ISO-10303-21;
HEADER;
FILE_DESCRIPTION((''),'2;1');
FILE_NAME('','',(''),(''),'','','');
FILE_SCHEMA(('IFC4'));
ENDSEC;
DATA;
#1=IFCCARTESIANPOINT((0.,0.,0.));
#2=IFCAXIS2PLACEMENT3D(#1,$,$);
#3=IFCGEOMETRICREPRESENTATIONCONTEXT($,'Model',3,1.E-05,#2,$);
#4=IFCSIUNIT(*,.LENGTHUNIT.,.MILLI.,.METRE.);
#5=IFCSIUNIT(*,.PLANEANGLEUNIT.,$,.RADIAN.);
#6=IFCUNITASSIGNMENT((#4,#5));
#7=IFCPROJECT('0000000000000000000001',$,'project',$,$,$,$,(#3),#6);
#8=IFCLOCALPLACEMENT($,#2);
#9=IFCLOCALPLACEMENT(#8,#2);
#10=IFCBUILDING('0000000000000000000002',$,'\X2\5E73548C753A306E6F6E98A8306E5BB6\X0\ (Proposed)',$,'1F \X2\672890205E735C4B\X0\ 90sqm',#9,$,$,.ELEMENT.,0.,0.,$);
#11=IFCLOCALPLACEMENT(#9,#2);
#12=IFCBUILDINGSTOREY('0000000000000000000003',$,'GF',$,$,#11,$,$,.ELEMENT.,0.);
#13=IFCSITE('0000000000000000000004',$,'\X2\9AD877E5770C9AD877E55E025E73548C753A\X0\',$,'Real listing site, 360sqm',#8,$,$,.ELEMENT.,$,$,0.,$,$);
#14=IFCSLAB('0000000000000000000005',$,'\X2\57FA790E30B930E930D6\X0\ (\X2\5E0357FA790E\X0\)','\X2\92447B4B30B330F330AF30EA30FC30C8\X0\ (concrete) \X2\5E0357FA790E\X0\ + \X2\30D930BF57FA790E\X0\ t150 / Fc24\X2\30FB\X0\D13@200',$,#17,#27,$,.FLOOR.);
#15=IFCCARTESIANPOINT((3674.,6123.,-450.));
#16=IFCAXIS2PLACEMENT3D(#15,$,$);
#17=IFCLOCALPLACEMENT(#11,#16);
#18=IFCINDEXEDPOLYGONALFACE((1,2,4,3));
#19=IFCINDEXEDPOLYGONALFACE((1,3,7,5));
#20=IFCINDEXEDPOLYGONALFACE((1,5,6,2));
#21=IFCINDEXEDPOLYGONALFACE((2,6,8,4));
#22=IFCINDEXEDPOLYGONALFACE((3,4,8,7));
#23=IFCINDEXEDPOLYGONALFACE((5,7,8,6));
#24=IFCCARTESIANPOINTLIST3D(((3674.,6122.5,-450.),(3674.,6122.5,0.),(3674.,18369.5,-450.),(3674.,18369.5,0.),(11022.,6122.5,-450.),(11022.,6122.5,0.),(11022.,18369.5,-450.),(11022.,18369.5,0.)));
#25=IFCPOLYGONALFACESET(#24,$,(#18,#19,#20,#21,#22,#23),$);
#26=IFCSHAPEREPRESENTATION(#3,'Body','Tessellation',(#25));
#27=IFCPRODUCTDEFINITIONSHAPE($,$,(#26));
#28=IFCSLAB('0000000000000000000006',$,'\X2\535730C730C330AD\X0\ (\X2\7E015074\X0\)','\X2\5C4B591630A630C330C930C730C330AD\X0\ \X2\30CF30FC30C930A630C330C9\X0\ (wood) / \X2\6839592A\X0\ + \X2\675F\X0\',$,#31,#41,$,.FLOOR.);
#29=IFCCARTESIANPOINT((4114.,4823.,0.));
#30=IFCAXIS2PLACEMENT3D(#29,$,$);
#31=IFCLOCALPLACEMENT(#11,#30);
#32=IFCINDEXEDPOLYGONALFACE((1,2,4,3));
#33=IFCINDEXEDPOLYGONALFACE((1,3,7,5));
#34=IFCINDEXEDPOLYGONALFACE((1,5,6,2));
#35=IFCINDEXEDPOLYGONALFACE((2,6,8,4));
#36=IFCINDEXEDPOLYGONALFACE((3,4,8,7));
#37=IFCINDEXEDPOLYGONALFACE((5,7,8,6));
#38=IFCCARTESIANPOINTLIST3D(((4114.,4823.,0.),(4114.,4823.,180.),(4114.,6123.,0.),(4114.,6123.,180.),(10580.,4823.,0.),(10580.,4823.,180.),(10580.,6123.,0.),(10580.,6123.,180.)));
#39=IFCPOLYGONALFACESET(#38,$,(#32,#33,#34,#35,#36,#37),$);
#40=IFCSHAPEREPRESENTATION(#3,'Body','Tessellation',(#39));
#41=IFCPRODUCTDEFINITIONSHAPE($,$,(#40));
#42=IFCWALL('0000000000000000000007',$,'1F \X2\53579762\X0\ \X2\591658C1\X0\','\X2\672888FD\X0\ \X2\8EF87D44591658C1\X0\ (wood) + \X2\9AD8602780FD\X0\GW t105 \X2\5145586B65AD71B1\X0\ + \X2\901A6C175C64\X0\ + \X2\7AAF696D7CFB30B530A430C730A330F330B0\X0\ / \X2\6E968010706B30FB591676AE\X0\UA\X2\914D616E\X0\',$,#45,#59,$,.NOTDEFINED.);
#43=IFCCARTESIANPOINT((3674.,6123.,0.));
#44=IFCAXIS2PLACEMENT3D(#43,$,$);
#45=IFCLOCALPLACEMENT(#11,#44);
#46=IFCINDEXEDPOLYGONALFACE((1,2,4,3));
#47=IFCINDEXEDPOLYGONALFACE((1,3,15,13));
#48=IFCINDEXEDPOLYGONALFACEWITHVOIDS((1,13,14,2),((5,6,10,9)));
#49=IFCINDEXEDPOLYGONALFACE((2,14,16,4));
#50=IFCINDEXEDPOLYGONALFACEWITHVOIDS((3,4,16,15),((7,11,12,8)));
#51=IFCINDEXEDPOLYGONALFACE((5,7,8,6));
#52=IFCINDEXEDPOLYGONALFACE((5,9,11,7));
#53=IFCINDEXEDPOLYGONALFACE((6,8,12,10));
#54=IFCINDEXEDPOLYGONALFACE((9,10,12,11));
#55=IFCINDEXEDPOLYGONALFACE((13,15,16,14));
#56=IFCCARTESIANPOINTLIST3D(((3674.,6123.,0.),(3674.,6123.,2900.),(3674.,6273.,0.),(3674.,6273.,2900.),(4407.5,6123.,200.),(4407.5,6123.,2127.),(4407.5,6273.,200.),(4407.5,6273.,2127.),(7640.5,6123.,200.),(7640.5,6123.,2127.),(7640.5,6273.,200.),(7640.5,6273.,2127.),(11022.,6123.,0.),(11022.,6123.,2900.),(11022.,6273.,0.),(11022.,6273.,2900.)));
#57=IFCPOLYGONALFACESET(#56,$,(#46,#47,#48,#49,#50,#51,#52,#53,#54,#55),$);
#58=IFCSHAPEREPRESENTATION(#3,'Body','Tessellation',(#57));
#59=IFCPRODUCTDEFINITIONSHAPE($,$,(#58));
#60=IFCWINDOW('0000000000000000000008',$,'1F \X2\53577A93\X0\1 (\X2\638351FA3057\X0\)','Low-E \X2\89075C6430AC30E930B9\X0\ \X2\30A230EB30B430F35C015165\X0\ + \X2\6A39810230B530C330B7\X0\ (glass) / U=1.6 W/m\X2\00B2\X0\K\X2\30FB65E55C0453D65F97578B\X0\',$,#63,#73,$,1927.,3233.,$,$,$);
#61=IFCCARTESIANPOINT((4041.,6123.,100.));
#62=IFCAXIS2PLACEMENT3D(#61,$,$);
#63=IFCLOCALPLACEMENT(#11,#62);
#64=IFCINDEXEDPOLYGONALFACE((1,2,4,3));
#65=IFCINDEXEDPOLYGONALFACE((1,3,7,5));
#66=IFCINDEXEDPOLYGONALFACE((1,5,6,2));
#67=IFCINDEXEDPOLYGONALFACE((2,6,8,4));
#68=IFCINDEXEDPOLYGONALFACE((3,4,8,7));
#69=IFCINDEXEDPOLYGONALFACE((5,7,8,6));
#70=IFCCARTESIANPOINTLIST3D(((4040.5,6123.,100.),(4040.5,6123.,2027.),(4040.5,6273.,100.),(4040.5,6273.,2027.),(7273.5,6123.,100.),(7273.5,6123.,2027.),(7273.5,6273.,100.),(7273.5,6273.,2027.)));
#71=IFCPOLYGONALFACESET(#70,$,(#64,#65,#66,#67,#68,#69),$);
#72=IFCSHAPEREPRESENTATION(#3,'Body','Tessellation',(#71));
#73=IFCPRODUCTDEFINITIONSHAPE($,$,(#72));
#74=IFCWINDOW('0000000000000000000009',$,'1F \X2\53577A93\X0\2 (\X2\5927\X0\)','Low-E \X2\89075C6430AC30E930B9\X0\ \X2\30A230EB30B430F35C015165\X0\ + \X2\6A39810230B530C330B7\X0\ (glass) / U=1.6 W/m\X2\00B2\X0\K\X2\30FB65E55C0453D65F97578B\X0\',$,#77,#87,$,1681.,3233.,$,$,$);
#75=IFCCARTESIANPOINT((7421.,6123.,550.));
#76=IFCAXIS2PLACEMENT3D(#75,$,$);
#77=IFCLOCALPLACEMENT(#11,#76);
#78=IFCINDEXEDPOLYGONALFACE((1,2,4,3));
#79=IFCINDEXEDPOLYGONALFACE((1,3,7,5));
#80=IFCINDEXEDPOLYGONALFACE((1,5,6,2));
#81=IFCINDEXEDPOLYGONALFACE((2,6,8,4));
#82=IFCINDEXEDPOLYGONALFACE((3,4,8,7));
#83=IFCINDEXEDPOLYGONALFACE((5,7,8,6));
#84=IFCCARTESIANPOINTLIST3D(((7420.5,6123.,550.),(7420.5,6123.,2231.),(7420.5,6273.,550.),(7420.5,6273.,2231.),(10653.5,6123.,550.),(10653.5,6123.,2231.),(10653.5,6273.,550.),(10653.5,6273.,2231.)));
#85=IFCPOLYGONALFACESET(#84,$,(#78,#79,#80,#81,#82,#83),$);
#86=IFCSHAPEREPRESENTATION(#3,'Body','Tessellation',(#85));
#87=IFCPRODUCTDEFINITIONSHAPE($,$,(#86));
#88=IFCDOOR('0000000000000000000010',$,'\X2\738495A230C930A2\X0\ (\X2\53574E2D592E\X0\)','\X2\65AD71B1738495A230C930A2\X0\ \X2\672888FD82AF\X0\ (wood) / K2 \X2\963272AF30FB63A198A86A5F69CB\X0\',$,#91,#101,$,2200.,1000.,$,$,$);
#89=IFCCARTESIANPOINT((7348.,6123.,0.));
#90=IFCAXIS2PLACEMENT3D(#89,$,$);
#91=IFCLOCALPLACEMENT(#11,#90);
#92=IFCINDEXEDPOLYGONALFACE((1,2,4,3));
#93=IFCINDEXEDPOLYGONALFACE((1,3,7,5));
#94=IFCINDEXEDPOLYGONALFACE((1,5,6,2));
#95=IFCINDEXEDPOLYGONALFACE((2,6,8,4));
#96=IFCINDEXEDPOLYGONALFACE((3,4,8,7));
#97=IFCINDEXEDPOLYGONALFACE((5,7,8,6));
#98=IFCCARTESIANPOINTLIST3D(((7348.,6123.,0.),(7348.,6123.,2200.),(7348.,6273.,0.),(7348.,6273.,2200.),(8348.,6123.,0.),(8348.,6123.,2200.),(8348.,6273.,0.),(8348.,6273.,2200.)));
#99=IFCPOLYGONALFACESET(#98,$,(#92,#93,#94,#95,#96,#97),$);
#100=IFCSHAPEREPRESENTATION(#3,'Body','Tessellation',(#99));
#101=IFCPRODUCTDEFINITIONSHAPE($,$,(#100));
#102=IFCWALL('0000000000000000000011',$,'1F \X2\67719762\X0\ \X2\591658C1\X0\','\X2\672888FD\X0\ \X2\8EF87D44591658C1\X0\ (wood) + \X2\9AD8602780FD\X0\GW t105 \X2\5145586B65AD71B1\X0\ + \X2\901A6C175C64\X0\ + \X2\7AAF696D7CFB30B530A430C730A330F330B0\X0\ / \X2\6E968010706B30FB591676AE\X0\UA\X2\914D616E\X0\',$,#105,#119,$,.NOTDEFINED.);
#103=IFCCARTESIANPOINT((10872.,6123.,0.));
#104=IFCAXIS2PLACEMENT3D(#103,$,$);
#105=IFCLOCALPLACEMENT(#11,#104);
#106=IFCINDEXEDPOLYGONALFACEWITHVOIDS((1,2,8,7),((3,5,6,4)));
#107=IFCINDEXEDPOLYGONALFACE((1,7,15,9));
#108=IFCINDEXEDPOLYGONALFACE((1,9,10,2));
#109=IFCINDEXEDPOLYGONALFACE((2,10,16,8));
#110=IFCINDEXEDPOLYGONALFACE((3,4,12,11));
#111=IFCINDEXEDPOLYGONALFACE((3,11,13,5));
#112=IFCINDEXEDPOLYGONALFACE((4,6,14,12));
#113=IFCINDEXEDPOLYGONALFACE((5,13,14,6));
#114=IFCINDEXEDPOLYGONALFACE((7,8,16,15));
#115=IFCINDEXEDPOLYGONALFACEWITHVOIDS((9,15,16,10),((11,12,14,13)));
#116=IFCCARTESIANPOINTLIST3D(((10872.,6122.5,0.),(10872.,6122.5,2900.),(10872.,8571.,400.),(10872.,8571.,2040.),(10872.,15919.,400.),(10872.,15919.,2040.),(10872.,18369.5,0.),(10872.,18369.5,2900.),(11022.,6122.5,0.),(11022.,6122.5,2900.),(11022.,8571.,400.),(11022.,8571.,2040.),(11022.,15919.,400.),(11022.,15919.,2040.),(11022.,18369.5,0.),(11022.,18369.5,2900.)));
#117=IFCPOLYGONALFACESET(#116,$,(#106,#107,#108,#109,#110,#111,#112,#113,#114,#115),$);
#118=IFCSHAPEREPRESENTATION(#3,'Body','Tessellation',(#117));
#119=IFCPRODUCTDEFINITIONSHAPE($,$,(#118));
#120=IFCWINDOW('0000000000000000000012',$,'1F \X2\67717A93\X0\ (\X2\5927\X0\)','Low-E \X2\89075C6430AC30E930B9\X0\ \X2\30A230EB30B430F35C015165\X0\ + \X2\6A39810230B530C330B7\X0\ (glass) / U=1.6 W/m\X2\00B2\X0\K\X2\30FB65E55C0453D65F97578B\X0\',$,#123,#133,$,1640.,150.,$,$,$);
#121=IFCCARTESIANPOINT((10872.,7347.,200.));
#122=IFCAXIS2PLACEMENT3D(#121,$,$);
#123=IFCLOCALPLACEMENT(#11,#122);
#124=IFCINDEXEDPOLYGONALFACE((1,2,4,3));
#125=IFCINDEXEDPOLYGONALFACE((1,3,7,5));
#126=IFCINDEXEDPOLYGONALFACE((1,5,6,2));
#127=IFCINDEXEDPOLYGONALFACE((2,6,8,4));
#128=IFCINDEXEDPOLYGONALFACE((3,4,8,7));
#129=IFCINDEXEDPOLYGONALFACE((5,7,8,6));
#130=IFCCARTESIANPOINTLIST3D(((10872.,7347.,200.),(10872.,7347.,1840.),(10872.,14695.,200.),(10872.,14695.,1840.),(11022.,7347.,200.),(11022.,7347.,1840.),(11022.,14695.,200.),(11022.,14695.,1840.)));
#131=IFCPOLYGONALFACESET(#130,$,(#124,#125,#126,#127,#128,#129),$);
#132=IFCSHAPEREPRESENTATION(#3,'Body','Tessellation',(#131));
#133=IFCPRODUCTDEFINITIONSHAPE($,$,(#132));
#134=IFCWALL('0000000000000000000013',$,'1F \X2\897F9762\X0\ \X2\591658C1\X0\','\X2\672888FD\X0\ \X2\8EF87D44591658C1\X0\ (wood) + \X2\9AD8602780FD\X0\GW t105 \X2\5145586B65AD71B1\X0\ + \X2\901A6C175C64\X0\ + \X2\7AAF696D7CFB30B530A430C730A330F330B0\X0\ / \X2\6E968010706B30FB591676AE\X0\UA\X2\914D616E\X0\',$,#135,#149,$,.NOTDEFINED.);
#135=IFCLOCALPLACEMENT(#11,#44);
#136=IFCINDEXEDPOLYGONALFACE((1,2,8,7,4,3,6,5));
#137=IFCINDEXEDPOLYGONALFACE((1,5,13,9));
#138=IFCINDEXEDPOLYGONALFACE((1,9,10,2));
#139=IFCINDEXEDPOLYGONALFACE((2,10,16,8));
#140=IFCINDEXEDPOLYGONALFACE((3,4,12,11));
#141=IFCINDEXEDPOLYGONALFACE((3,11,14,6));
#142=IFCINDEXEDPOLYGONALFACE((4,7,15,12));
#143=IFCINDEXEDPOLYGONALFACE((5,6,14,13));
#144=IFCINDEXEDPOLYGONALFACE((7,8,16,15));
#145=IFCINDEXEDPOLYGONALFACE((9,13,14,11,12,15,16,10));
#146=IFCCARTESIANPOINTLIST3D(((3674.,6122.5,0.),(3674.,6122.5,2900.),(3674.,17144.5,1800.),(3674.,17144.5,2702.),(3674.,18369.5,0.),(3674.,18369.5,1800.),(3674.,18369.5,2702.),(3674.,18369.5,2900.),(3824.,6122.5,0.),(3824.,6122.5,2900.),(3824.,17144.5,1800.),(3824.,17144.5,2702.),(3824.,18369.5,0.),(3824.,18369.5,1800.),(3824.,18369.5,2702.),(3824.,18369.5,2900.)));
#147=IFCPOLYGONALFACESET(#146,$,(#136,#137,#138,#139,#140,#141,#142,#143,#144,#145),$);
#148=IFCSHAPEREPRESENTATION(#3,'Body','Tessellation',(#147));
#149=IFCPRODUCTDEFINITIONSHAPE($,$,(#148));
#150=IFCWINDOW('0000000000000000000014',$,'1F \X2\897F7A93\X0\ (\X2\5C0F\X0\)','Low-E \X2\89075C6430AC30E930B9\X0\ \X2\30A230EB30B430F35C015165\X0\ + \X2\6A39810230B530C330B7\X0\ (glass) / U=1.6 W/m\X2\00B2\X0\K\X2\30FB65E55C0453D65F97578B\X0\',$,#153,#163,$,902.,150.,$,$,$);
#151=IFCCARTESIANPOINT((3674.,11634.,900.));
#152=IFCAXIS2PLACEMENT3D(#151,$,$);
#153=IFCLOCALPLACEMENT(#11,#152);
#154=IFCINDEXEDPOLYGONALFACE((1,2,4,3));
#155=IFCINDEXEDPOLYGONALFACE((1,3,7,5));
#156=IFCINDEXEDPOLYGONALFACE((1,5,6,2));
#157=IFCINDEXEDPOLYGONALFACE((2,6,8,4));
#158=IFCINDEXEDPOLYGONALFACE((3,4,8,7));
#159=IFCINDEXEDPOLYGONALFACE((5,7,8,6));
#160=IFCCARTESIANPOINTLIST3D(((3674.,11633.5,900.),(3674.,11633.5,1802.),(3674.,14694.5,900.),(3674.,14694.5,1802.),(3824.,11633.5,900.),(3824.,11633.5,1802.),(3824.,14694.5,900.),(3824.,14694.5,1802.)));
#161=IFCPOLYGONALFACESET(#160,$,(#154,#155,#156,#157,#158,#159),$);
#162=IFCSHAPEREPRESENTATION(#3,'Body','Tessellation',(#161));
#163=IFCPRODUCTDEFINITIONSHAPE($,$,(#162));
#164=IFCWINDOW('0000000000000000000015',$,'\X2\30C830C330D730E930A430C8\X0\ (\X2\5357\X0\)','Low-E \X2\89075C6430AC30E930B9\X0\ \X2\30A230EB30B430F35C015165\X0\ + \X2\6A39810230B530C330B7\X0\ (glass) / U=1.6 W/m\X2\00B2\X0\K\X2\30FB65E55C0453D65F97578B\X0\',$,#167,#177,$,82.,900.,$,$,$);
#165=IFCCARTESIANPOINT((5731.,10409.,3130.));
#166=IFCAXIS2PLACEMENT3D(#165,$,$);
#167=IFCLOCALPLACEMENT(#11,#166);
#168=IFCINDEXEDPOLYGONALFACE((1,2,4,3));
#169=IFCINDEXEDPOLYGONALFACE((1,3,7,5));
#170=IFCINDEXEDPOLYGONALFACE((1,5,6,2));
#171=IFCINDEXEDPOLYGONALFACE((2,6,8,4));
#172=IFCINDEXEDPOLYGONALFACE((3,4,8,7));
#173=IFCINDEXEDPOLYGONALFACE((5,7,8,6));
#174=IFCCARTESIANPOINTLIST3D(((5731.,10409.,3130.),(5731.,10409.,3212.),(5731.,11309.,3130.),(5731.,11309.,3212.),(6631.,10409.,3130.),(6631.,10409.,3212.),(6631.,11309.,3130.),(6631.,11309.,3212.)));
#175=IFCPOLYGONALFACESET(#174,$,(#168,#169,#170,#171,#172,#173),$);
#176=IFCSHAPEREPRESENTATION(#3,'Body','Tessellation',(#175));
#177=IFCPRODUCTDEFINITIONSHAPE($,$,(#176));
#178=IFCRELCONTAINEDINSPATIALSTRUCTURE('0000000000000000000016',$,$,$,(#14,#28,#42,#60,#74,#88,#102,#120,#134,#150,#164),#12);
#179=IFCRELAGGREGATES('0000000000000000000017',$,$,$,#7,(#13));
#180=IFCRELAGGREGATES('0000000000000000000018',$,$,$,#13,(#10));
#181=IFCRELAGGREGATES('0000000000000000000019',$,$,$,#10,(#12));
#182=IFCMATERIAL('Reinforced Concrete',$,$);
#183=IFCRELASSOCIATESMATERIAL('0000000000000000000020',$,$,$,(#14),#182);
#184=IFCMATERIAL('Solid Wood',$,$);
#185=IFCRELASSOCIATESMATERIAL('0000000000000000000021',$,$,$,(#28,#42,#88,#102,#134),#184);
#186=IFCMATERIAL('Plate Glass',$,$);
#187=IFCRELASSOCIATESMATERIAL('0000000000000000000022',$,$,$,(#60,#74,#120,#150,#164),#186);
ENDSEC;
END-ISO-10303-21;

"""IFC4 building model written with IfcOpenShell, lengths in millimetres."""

from ifc_helpers import new_model, si_unit, frame, frame_2d, origin, place, context, project, spatial, rectangle, extrude, material, element, fill, save


model = new_model("IFC4")

# Units and contexts
model_context = context("Model", 3, precision=1e-05, world=origin())
ifc_project = project(units=[si_unit("LENGTHUNIT", "METRE", prefix="MILLI"), si_unit("PLANEANGLEUNIT", "RADIAN")], contexts=[model_context])

# Site, building, storey
site_placement = place(None, origin())
site = spatial("IfcSite", under=ifc_project, at=site_placement, Name="高知県高知市平和町", ObjectType="Real listing site, 360sqm", CompositionType="ELEMENT", RefElevation=0.0)
building_placement = place(site_placement, origin())
building = spatial("IfcBuilding", under=site, at=building_placement, Name="平和町の潮風の家 (Proposed)", ObjectType="1F 木造平屋 90sqm", CompositionType="ELEMENT", ElevationOfRefHeight=0.0, ElevationOfTerrain=0.0)
storey_placement = place(building_placement, origin())
storey = spatial("IfcBuildingStorey", under=building, at=storey_placement, Name="GF", CompositionType="ELEMENT", Elevation=0.0)

# Slabs
ifc_material_1 = material(Name="Reinforced Concrete")
slab_1_placement = place(storey_placement, frame((3674.0, 6123.0, -450.0)))
element("IfcSlab", 1, at=slab_1_placement, inside=storey, material=ifc_material_1, Name="基礎スラブ (布基礎)", Description="鉄筋コンクリート (concrete) 布基礎 + ベタ基礎 t150 / Fc24・D13@200", PredefinedType="FLOOR", context=model_context, shape_type="SweptSolid", body=[
    extrude(rectangle(XDim=7348.0, YDim=12247.0, at=frame_2d((3674.0, 6123.0))), frame((3674.0, 6123.0, -450.0)), (0.0, 0.0, 1.0), 450.0),
])
ifc_material_2 = material(Name="Solid Wood")
slab_2_placement = place(storey_placement, frame((4114.0, 4823.0, 0.0)))
element("IfcSlab", 2, at=slab_2_placement, inside=storey, material=ifc_material_2, Name="南デッキ (縁側)", Description="屋外ウッドデッキ ハードウッド (wood) / 根太 + 束", PredefinedType="FLOOR", context=model_context, shape_type="SweptSolid", body=[
    extrude(rectangle(XDim=6466.0, YDim=1300.0, at=frame_2d((3233.0, 650.0))), frame((4114.0, 4823.0, 0.0)), (0.0, 0.0, 1.0), 180.0),
])

# Wall, openings, windows, door
wall_1_placement = place(storey_placement, frame((3674.0, 6123.0, 0.0)))
wall_1 = element("IfcWall", 3, at=wall_1_placement, inside=storey, material=ifc_material_2, Name="1F 南面 外壁", Description="木製 軸組外壁 (wood) + 高性能GW t105 充填断熱 + 通気層 + 窯業系サイディング / 準耐火・外皮UA配慮", PredefinedType="NOTDEFINED", context=model_context, shape_type="SweptSolid", body=[
    extrude(rectangle(XDim=7348.0, YDim=150.0, at=frame_2d((3674.0, 75.0))), frame((3674.0, 6123.0, 0.0)), (0.0, 0.0, 1.0), 2900.0),
])
opening_1_placement = place(storey_placement, frame((4041.0, 6123.0, 100.0)))
opening_1 = element("IfcOpeningElement", 4, at=opening_1_placement, cuts=wall_1, PredefinedType="NOTDEFINED", context=model_context, shape_type="SweptSolid", body=[
    extrude(rectangle(XDim=3233.0, YDim=150.0, at=frame_2d((1616.0, 75.0))), frame((4041.0, 6123.0, 100.0)), (0.0, 0.0, 1.0), 1927.0),
])
opening_2_placement = place(storey_placement, frame((7421.0, 6123.0, 550.0)))
opening_2 = element("IfcOpeningElement", 5, at=opening_2_placement, cuts=wall_1, PredefinedType="NOTDEFINED", context=model_context, shape_type="SweptSolid", body=[
    extrude(rectangle(XDim=3233.0, YDim=150.0, at=frame_2d((1616.0, 75.0))), frame((7421.0, 6123.0, 550.0)), (0.0, 0.0, 1.0), 1681.0),
])
opening_3_placement = place(storey_placement, frame((7348.0, 6123.0, 0.0)))
opening_3 = element("IfcOpeningElement", 6, at=opening_3_placement, cuts=wall_1, PredefinedType="NOTDEFINED", context=model_context, shape_type="SweptSolid", body=[
    extrude(rectangle(XDim=1000.0, YDim=150.0, at=frame_2d((500.0, 75.0))), frame((7348.0, 6123.0, 0.0)), (0.0, 0.0, 1.0), 2200.0),
])
ifc_material_3 = material(Name="Plate Glass")
window_1_placement = place(storey_placement, frame((4041.0, 6123.0, 100.0)))
window_1 = element("IfcWindow", 7, at=window_1_placement, inside=storey, material=ifc_material_3, Name="1F 南窓1 (掃出し)", Description="Low-E 複層ガラス アルゴン封入 + 樹脂サッシ (glass) / U=1.6 W/m²K・日射取得型", OverallHeight=1927.0, OverallWidth=3233.0, context=model_context, shape_type="SweptSolid", body=[
    extrude(rectangle(XDim=3233.0, YDim=150.0, at=frame_2d((1616.0, 75.0))), frame((4041.0, 6123.0, 100.0)), (0.0, 0.0, 1.0), 1927.0),
])
fill(opening_1, window_1)
window_2_placement = place(storey_placement, frame((7421.0, 6123.0, 550.0)))
window_2 = element("IfcWindow", 8, at=window_2_placement, inside=storey, material=ifc_material_3, Name="1F 南窓2 (大)", Description="Low-E 複層ガラス アルゴン封入 + 樹脂サッシ (glass) / U=1.6 W/m²K・日射取得型", OverallHeight=1681.0, OverallWidth=3233.0, context=model_context, shape_type="SweptSolid", body=[
    extrude(rectangle(XDim=3233.0, YDim=150.0, at=frame_2d((1616.0, 75.0))), frame((7421.0, 6123.0, 550.0)), (0.0, 0.0, 1.0), 1681.0),
])
fill(opening_2, window_2)
door_placement = place(storey_placement, frame((7348.0, 6123.0, 0.0)))
door = element("IfcDoor", 9, at=door_placement, inside=storey, material=ifc_material_2, Name="玄関ドア (南中央)", Description="断熱玄関ドア 木製芯 (wood) / K2 防犯・採風機構", OverallHeight=2200.0, OverallWidth=1000.0, context=model_context, shape_type="SweptSolid", body=[
    extrude(rectangle(XDim=1000.0, YDim=150.0, at=frame_2d((500.0, 75.0))), frame((7348.0, 6123.0, 0.0)), (0.0, 0.0, 1.0), 2200.0),
])
fill(opening_3, door)

# Walls, openings, windows
wall_2_placement = place(storey_placement, frame((10872.0, 6123.0, 0.0)))
wall_2 = element("IfcWall", 10, at=wall_2_placement, inside=storey, material=ifc_material_2, Name="1F 東面 外壁", Description="木製 軸組外壁 (wood) + 高性能GW t105 充填断熱 + 通気層 + 窯業系サイディング / 準耐火・外皮UA配慮", PredefinedType="NOTDEFINED", context=model_context, shape_type="SweptSolid", body=[
    extrude(rectangle(XDim=150.0, YDim=12247.0, at=frame_2d((75.0, 6123.0))), frame((10872.0, 6123.0, 0.0)), (0.0, 0.0, 1.0), 2900.0),
])
opening_4_placement = place(storey_placement, frame((10872.0, 7347.0, 200.0)))
opening_4 = element("IfcOpeningElement", 11, at=opening_4_placement, cuts=wall_2, PredefinedType="NOTDEFINED", context=model_context, shape_type="SweptSolid", body=[
    extrude(rectangle(XDim=150.0, YDim=7348.0, at=frame_2d((75.0, 3674.0))), frame((10872.0, 7347.0, 200.0)), (0.0, 0.0, 1.0), 1640.0),
])
window_3_placement = place(storey_placement, frame((10872.0, 7347.0, 200.0)))
window_3 = element("IfcWindow", 12, at=window_3_placement, inside=storey, material=ifc_material_3, Name="1F 東窓 (大)", Description="Low-E 複層ガラス アルゴン封入 + 樹脂サッシ (glass) / U=1.6 W/m²K・日射取得型", OverallHeight=1640.0, OverallWidth=150.0, context=model_context, shape_type="SweptSolid", body=[
    extrude(rectangle(XDim=150.0, YDim=7348.0, at=frame_2d((75.0, 3674.0))), frame((10872.0, 7347.0, 200.0)), (0.0, 0.0, 1.0), 1640.0),
])
fill(opening_4, window_3)
wall_3_placement = place(storey_placement, frame((3674.0, 6123.0, 0.0)))
wall_3 = element("IfcWall", 13, at=wall_3_placement, inside=storey, material=ifc_material_2, Name="1F 西面 外壁", Description="木製 軸組外壁 (wood) + 高性能GW t105 充填断熱 + 通気層 + 窯業系サイディング / 準耐火・外皮UA配慮", PredefinedType="NOTDEFINED", context=model_context, shape_type="SweptSolid", body=[
    extrude(rectangle(XDim=150.0, YDim=12247.0, at=frame_2d((75.0, 6123.0))), frame((3674.0, 6123.0, 0.0)), (0.0, 0.0, 1.0), 2900.0),
])
opening_5_placement = place(storey_placement, frame((3674.0, 11634.0, 900.0)))
opening_5 = element("IfcOpeningElement", 14, at=opening_5_placement, cuts=wall_3, PredefinedType="NOTDEFINED", context=model_context, shape_type="SweptSolid", body=[
    extrude(rectangle(XDim=150.0, YDim=3061.0, at=frame_2d((75.0, 1530.0))), frame((3674.0, 11634.0, 900.0)), (0.0, 0.0, 1.0), 902.0),
])
window_4_placement = place(storey_placement, frame((3674.0, 11634.0, 900.0)))
window_4 = element("IfcWindow", 15, at=window_4_placement, inside=storey, material=ifc_material_3, Name="1F 西窓 (小)", Description="Low-E 複層ガラス アルゴン封入 + 樹脂サッシ (glass) / U=1.6 W/m²K・日射取得型", OverallHeight=902.0, OverallWidth=150.0, context=model_context, shape_type="SweptSolid", body=[
    extrude(rectangle(XDim=150.0, YDim=3061.0, at=frame_2d((75.0, 1530.0))), frame((3674.0, 11634.0, 900.0)), (0.0, 0.0, 1.0), 902.0),
])
fill(opening_5, window_4)

# Window
window_5_placement = place(storey_placement, frame((5731.0, 10409.0, 3130.0)))
element("IfcWindow", 16, at=window_5_placement, inside=storey, material=ifc_material_3, Name="トップライト (南)", Description="Low-E 複層ガラス アルゴン封入 + 樹脂サッシ (glass) / U=1.6 W/m²K・日射取得型", OverallHeight=82.0, OverallWidth=900.0, context=model_context, shape_type="SweptSolid", body=[
    extrude(rectangle(XDim=900.0, YDim=900.0, at=frame_2d((450.0, 450.0))), frame((5731.0, 10409.0, 3130.0)), (0.0, 0.0, 1.0), 82.0),
])

save(model, "model.ifc")
